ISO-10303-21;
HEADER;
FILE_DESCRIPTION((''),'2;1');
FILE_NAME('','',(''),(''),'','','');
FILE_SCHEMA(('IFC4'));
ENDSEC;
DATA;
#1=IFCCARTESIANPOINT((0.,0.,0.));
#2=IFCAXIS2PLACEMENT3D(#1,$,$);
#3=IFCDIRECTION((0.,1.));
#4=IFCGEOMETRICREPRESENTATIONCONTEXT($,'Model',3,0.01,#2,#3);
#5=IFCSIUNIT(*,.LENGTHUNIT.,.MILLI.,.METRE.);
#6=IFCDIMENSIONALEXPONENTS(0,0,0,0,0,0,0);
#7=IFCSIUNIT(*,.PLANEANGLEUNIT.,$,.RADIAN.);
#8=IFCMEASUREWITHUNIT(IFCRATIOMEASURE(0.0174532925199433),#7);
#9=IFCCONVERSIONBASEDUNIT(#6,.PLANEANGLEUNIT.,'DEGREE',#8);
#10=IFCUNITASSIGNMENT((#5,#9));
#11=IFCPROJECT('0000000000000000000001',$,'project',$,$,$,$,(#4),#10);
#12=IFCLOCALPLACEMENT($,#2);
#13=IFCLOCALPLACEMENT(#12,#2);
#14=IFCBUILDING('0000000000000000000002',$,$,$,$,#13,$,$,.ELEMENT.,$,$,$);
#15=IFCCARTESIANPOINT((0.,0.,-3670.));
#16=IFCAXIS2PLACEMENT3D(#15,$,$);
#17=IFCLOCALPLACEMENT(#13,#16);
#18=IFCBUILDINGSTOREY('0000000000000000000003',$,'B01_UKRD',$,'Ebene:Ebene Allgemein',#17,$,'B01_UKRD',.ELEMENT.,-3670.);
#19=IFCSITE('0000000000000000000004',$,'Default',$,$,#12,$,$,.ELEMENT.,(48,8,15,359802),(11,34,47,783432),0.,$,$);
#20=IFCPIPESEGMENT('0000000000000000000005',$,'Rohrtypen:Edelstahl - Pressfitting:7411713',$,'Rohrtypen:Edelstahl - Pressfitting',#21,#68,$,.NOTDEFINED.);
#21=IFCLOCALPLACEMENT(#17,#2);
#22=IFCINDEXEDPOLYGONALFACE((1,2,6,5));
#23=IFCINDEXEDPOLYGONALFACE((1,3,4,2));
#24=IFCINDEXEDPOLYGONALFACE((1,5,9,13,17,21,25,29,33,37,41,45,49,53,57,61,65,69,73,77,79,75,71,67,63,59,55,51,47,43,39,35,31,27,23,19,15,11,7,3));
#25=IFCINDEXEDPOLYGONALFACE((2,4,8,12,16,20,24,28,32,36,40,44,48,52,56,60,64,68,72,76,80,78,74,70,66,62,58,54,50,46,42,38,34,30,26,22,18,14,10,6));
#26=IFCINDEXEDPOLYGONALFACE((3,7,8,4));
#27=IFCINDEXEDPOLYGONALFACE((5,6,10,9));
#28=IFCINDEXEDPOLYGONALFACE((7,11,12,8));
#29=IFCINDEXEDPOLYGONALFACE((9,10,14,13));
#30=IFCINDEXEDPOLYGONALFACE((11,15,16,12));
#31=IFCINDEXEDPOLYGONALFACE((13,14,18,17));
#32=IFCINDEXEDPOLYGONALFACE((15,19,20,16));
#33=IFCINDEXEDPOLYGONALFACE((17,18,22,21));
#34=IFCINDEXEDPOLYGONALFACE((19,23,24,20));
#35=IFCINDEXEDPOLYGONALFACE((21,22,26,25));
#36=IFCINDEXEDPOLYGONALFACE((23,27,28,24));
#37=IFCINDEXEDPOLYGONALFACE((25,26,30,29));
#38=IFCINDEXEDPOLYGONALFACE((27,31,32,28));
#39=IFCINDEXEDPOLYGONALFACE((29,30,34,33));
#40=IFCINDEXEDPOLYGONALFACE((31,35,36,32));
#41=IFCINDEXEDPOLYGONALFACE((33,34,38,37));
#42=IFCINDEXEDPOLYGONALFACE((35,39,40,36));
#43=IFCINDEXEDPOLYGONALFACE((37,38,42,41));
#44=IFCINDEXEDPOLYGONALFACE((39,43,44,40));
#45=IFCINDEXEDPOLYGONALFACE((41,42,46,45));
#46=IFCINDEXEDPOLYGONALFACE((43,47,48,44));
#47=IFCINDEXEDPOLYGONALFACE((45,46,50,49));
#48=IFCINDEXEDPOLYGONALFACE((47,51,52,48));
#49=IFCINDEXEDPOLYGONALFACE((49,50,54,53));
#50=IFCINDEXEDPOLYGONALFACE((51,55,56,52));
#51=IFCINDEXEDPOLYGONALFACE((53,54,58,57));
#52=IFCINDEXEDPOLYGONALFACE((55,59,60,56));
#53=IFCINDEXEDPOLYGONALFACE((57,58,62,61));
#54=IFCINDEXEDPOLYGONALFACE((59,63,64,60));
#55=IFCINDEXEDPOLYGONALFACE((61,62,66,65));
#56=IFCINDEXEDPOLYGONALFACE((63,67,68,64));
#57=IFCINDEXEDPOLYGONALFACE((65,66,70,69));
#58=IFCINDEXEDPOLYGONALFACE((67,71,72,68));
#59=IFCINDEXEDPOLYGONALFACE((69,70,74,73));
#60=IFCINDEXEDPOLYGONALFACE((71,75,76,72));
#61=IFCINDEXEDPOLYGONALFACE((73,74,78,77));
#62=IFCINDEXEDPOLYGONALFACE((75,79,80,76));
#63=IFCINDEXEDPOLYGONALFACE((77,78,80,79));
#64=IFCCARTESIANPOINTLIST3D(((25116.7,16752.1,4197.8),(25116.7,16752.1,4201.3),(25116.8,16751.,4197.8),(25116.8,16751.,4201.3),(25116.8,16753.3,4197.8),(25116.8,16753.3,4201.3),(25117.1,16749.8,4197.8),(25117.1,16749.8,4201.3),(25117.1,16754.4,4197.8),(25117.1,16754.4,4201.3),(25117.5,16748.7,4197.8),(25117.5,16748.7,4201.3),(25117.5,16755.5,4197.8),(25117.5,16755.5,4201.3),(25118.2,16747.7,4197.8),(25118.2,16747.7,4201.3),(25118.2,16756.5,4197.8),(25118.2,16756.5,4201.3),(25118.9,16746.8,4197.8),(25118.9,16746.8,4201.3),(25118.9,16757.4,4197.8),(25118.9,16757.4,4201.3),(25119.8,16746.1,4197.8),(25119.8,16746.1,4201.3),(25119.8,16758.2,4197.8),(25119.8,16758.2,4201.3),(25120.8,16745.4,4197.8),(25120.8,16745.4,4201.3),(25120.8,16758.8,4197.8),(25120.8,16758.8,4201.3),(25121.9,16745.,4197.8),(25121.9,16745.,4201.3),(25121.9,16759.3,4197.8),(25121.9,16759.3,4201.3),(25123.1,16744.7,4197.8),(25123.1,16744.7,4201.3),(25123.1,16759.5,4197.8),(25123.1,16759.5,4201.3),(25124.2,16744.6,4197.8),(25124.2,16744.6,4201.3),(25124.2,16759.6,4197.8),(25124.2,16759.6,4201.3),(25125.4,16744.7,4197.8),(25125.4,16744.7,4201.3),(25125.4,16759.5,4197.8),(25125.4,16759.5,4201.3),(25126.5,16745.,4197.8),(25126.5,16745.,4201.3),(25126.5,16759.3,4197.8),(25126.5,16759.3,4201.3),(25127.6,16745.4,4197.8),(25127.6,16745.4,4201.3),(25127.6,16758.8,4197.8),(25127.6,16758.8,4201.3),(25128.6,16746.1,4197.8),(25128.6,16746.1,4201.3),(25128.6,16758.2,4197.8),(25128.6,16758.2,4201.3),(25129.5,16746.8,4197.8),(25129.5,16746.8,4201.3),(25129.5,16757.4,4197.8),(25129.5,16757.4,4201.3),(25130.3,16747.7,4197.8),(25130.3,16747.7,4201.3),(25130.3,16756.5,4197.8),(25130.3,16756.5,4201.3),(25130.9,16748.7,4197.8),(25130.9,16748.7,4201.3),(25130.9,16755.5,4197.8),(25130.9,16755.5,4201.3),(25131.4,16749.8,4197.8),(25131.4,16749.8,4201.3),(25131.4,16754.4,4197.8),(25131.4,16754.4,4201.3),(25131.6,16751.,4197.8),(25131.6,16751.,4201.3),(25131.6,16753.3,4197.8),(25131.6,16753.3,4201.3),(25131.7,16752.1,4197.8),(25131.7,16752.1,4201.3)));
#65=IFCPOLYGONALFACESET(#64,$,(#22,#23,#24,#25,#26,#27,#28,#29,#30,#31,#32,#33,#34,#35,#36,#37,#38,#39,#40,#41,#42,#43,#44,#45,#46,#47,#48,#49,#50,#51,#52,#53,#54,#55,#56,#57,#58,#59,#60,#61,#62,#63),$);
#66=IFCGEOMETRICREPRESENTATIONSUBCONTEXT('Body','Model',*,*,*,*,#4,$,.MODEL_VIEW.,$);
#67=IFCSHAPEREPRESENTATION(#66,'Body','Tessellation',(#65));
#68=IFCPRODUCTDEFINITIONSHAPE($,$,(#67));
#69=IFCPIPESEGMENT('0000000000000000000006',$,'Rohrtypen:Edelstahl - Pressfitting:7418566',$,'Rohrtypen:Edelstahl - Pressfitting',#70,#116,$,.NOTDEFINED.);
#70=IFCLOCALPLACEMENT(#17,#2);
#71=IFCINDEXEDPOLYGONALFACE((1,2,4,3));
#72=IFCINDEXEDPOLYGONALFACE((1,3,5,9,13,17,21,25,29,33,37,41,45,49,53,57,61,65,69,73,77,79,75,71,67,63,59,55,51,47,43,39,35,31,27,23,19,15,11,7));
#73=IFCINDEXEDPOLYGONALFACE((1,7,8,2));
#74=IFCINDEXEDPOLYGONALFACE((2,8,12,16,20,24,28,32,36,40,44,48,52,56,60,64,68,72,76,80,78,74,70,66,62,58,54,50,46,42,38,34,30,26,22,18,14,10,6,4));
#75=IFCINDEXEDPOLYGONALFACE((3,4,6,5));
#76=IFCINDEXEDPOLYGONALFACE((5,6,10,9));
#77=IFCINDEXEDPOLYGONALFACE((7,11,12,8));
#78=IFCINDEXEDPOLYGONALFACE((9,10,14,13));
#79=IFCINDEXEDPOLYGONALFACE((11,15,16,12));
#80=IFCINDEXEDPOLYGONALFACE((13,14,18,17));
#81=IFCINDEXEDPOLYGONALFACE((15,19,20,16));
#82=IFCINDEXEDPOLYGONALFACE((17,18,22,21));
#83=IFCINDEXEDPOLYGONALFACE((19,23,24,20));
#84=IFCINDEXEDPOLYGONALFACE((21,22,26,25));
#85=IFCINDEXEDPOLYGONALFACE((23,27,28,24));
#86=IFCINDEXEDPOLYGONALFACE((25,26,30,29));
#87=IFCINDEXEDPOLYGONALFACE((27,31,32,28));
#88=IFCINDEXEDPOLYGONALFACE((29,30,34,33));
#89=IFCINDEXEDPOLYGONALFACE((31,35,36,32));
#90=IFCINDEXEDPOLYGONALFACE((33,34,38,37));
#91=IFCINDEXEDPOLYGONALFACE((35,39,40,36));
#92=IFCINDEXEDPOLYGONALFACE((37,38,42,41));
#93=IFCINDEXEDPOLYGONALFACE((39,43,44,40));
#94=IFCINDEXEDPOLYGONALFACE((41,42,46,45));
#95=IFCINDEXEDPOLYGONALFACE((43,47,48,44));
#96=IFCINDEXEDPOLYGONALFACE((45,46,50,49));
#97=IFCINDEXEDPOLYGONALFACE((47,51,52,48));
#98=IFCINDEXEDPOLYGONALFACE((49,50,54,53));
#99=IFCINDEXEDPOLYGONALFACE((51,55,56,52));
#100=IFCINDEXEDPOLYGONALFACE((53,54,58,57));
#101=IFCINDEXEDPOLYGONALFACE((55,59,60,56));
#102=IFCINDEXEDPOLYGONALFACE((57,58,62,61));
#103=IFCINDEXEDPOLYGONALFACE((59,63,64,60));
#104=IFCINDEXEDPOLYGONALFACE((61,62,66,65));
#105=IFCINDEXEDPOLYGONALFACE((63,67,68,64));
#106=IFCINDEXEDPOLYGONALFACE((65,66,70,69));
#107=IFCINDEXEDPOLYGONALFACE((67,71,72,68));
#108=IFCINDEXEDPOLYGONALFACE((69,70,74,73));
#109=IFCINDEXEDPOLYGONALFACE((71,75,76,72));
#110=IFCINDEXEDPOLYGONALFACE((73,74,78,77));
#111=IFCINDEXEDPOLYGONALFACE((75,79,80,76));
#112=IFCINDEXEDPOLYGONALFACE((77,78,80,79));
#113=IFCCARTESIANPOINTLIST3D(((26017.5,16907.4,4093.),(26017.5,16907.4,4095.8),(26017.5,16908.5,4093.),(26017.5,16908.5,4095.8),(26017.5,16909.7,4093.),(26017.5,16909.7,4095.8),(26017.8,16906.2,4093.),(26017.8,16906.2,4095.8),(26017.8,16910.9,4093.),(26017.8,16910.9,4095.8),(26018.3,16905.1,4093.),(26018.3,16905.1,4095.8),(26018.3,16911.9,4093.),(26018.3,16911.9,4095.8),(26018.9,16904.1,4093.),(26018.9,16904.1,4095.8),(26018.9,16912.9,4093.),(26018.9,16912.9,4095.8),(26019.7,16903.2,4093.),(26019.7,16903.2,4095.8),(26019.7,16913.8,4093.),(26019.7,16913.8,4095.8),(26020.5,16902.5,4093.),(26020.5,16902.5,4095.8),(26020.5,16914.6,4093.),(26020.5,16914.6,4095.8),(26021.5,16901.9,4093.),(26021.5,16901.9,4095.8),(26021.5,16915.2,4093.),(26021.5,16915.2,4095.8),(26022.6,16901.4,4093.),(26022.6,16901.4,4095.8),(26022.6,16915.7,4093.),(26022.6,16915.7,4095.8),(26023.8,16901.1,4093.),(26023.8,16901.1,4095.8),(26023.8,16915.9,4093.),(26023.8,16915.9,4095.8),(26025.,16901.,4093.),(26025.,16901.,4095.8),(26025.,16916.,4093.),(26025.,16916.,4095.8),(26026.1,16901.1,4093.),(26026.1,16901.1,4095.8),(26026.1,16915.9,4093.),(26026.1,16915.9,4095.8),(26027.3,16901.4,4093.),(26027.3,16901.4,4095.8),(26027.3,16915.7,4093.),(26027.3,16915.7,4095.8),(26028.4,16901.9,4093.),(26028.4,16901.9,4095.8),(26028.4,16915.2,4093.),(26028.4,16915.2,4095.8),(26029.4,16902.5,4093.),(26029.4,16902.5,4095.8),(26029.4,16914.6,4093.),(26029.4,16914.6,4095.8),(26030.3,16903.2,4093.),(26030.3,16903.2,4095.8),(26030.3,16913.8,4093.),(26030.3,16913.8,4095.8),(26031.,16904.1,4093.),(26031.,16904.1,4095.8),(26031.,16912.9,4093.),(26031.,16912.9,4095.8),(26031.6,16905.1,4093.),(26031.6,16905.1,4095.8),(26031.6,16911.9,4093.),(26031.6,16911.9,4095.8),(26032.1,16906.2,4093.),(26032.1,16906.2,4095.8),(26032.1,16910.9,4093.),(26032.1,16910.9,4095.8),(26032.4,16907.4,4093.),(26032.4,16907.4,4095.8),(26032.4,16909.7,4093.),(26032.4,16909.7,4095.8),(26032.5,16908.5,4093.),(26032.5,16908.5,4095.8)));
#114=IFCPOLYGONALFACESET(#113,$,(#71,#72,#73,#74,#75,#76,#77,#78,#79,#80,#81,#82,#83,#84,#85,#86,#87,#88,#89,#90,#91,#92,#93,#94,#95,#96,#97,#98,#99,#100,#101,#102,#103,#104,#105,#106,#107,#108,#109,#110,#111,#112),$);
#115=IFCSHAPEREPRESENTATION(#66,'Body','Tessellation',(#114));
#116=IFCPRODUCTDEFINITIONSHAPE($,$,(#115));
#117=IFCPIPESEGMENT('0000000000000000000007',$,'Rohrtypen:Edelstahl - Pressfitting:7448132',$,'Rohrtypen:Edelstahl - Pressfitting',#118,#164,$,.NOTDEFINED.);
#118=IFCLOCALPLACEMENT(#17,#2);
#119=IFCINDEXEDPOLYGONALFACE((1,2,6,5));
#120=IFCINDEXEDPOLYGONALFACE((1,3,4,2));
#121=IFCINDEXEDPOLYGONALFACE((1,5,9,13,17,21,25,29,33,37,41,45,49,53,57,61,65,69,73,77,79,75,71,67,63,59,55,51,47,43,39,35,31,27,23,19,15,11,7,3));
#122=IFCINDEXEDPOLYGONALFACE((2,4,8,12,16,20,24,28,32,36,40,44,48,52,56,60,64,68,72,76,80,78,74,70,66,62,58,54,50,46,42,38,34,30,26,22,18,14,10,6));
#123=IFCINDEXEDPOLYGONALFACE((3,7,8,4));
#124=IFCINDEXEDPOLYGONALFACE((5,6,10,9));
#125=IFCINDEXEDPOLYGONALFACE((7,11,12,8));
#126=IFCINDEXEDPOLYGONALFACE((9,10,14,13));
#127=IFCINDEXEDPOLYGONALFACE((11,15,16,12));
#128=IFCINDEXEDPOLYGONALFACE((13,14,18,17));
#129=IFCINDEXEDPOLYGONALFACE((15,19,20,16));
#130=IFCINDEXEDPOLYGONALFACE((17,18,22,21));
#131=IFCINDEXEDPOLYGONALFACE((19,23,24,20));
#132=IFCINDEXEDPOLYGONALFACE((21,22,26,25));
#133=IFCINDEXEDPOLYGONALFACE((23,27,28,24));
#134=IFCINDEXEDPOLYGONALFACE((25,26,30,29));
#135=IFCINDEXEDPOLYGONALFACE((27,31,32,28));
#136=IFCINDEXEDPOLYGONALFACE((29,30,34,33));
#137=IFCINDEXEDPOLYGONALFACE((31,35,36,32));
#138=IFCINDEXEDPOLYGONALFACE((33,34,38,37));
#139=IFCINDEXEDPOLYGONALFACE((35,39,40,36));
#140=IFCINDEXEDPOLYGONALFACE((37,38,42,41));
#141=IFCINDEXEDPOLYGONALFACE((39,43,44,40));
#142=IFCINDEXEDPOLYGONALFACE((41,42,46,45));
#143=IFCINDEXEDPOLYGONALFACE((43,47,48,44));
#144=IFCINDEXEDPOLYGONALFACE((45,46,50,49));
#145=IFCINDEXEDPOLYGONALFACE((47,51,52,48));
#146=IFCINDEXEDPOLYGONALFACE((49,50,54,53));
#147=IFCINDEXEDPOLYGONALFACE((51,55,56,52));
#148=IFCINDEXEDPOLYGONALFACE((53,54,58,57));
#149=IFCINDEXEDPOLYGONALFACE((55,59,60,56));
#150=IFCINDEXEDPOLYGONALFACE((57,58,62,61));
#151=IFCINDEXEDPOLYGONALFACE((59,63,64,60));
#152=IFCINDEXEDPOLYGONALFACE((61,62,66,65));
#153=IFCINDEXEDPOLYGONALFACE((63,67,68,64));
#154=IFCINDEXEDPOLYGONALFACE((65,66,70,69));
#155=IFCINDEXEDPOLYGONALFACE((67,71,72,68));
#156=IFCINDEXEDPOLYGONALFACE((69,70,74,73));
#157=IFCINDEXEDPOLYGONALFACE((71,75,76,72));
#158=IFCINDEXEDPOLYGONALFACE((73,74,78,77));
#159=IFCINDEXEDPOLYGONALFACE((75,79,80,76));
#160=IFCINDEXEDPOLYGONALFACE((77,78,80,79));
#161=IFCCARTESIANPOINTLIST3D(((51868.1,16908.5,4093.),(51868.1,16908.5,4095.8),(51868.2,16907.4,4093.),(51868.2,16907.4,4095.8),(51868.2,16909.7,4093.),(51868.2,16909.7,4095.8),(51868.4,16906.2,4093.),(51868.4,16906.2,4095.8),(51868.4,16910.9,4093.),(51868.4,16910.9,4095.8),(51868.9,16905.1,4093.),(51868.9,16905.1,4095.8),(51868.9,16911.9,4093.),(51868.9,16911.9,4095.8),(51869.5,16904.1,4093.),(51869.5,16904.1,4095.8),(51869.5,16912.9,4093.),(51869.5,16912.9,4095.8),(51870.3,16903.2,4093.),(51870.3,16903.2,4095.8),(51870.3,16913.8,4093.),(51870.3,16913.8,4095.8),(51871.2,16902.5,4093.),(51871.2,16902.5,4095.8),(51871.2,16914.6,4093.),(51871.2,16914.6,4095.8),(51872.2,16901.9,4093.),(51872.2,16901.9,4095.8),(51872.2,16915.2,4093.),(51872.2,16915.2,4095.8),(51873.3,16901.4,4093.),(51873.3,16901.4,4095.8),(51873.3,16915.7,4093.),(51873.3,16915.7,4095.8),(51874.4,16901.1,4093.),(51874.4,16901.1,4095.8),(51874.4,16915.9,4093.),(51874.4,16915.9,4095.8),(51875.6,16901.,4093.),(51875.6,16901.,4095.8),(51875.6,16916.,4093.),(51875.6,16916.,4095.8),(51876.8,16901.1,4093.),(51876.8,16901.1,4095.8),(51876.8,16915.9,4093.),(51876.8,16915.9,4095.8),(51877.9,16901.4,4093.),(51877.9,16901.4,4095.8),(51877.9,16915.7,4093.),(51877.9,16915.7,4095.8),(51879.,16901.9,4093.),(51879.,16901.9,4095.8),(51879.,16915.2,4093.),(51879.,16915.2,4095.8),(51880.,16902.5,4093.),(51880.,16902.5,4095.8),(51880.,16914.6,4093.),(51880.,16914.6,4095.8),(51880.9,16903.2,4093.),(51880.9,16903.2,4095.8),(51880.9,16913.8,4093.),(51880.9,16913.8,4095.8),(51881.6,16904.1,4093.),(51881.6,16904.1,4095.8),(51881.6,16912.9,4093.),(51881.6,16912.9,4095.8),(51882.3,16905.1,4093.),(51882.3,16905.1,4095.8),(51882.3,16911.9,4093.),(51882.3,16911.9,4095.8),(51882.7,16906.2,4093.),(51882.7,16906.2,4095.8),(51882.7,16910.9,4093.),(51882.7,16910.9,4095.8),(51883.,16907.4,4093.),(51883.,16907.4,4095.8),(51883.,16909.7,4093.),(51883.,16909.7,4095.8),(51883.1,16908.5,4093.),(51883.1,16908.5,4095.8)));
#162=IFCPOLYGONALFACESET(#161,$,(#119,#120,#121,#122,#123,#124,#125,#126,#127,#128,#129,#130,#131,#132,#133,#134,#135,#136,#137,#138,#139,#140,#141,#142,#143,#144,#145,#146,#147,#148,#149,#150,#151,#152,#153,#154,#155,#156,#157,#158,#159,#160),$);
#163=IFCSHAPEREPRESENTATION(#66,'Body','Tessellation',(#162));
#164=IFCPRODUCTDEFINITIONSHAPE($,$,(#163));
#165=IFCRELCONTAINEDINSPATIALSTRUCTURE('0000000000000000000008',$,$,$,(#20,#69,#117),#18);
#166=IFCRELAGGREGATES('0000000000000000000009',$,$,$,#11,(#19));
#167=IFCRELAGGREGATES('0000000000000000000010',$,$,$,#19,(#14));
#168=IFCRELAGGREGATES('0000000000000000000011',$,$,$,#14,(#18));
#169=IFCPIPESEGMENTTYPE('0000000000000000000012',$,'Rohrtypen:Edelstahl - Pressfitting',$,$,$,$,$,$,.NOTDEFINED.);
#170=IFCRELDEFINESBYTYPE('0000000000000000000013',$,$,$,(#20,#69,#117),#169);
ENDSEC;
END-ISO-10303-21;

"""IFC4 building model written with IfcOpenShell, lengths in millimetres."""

from ifc_helpers import new_model, entity, si_unit, converted_unit, direction, frame, origin, place, context, subcontext, project, spatial, indexed_curve, outline, extrude, type_object, element, save


model = new_model("IFC4")

# Units and contexts
model_context = context("Model", 3, precision=0.01, world=origin(), true_north=direction((0.0, 1.0)))
body_context = subcontext(model_context, "Body", "Model", "MODEL_VIEW")
ifc_project = project(units=[si_unit("LENGTHUNIT", "METRE", prefix="MILLI"), converted_unit("PLANEANGLEUNIT", "DEGREE", entity("IfcRatioMeasure", 0.0174532925199433), si_unit("PLANEANGLEUNIT", "RADIAN"), dimensions=[0, 0, 0, 0, 0, 0, 0])], contexts=[model_context])

# Site, building, storey
site_placement = place(None, origin())
site = spatial("IfcSite", under=ifc_project, at=site_placement, Name="Default", CompositionType="ELEMENT", RefLatitude=(48, 8, 15, 359802), RefLongitude=(11, 34, 47, 783432), RefElevation=0.0)
building_placement = place(site_placement, origin())
building = spatial("IfcBuilding", under=site, at=building_placement, CompositionType="ELEMENT")
storey_placement = place(building_placement, frame((0.0, 0.0, -3670.0)))
storey = spatial("IfcBuildingStorey", under=building, at=storey_placement, Name="B01_UKRD", ObjectType="Ebene:Ebene Allgemein", LongName="B01_UKRD", CompositionType="ELEMENT", Elevation=-3670.0)

# Pipe segments
pipe_segment_type = type_object("IfcPipeSegmentType", Name="Rohrtypen:Edelstahl - Pressfitting", PredefinedType="NOTDEFINED")
pipe_segment_1_placement = place(storey_placement, origin())
element("IfcPipeSegment", 1, at=pipe_segment_1_placement, inside=storey, type_object=pipe_segment_type, Name="Rohrtypen:Edelstahl - Pressfitting:7411713", ObjectType="Rohrtypen:Edelstahl - Pressfitting", PredefinedType="NOTDEFINED", context=body_context, shape_type="SweptSolid", body=[
    extrude(outline(indexed_curve([(7.5, 0.0), (7.4, 1.2), (7.1, 2.3), (6.7, 3.4), (6.1, 4.4), (5.3, 5.3), (4.4, 6.1), (3.4, 6.7), (2.3, 7.1), (1.2, 7.4), (0.0, 7.5), (-1.2, 7.4), (-2.3, 7.1), (-3.4, 6.7), (-4.4, 6.1), (-5.3, 5.3), (-6.1, 4.4), (-6.7, 3.4), (-7.1, 2.3), (-7.4, 1.2), (-7.5, 0.0), (-7.4, -1.2), (-7.1, -2.3), (-6.7, -3.4), (-6.1, -4.4), (-5.3, -5.3), (-4.4, -6.1), (-3.4, -6.7), (-2.3, -7.1), (-1.2, -7.4), (0.0, -7.5), (1.2, -7.4), (2.3, -7.1), (3.4, -6.7), (4.4, -6.1), (5.3, -5.3), (6.1, -4.4), (6.7, -3.4), (7.1, -2.3), (7.4, -1.2), (7.5, 0.0)], self_intersect=False)), frame((25124.2, 16752.1, 4197.8), z_axis=(0.0, 0.0, 1.0), x_axis=(-1.0, 0.0, 0.0)), (0.0, 0.0, 1.0), 3.5),
])
pipe_segment_2_placement = place(storey_placement, origin())
element("IfcPipeSegment", 2, at=pipe_segment_2_placement, inside=storey, type_object=pipe_segment_type, Name="Rohrtypen:Edelstahl - Pressfitting:7418566", ObjectType="Rohrtypen:Edelstahl - Pressfitting", PredefinedType="NOTDEFINED", context=body_context, shape_type="SweptSolid", body=[
    extrude(outline(indexed_curve([(7.5, 0.0), (7.4, 1.2), (7.1, 2.3), (6.7, 3.4), (6.1, 4.4), (5.3, 5.3), (4.4, 6.1), (3.4, 6.7), (2.3, 7.1), (1.2, 7.4), (0.0, 7.5), (-1.2, 7.4), (-2.3, 7.1), (-3.4, 6.7), (-4.4, 6.1), (-5.3, 5.3), (-6.1, 4.4), (-6.7, 3.4), (-7.1, 2.3), (-7.4, 1.2), (-7.5, 0.0), (-7.4, -1.2), (-7.1, -2.3), (-6.7, -3.4), (-6.1, -4.4), (-5.3, -5.3), (-4.4, -6.1), (-3.4, -6.7), (-2.3, -7.1), (-1.2, -7.4), (0.0, -7.5), (1.2, -7.4), (2.3, -7.1), (3.4, -6.7), (4.4, -6.1), (5.3, -5.3), (6.1, -4.4), (6.7, -3.4), (7.1, -2.3), (7.4, -1.2), (7.5, 0.0)], self_intersect=False)), frame((26025.0, 16908.5, 4093.0), z_axis=(0.0, 0.0, 1.0), x_axis=(-1.0, 0.0, 0.0)), (0.0, 0.0, 1.0), 2.8),
])
pipe_segment_3_placement = place(storey_placement, origin())
element("IfcPipeSegment", 3, at=pipe_segment_3_placement, inside=storey, type_object=pipe_segment_type, Name="Rohrtypen:Edelstahl - Pressfitting:7448132", ObjectType="Rohrtypen:Edelstahl - Pressfitting", PredefinedType="NOTDEFINED", context=body_context, shape_type="SweptSolid", body=[
    extrude(outline(indexed_curve([(7.5, 0.0), (7.4, 1.2), (7.1, 2.3), (6.7, 3.4), (6.1, 4.4), (5.3, 5.3), (4.4, 6.1), (3.4, 6.7), (2.3, 7.1), (1.2, 7.4), (0.0, 7.5), (-1.2, 7.4), (-2.3, 7.1), (-3.4, 6.7), (-4.4, 6.1), (-5.3, 5.3), (-6.1, 4.4), (-6.7, 3.4), (-7.1, 2.3), (-7.4, 1.2), (-7.5, 0.0), (-7.4, -1.2), (-7.1, -2.3), (-6.7, -3.4), (-6.1, -4.4), (-5.3, -5.3), (-4.4, -6.1), (-3.4, -6.7), (-2.3, -7.1), (-1.2, -7.4), (0.0, -7.5), (1.2, -7.4), (2.3, -7.1), (3.4, -6.7), (4.4, -6.1), (5.3, -5.3), (6.1, -4.4), (6.7, -3.4), (7.1, -2.3), (7.4, -1.2), (7.5, 0.0)], self_intersect=False)), frame((51875.6, 16908.5, 4093.0), z_axis=(0.0, 0.0, 1.0), x_axis=(-1.0, 0.0, 0.0)), (0.0, 0.0, 1.0), 2.8),
])

save(model, "model.ifc")
